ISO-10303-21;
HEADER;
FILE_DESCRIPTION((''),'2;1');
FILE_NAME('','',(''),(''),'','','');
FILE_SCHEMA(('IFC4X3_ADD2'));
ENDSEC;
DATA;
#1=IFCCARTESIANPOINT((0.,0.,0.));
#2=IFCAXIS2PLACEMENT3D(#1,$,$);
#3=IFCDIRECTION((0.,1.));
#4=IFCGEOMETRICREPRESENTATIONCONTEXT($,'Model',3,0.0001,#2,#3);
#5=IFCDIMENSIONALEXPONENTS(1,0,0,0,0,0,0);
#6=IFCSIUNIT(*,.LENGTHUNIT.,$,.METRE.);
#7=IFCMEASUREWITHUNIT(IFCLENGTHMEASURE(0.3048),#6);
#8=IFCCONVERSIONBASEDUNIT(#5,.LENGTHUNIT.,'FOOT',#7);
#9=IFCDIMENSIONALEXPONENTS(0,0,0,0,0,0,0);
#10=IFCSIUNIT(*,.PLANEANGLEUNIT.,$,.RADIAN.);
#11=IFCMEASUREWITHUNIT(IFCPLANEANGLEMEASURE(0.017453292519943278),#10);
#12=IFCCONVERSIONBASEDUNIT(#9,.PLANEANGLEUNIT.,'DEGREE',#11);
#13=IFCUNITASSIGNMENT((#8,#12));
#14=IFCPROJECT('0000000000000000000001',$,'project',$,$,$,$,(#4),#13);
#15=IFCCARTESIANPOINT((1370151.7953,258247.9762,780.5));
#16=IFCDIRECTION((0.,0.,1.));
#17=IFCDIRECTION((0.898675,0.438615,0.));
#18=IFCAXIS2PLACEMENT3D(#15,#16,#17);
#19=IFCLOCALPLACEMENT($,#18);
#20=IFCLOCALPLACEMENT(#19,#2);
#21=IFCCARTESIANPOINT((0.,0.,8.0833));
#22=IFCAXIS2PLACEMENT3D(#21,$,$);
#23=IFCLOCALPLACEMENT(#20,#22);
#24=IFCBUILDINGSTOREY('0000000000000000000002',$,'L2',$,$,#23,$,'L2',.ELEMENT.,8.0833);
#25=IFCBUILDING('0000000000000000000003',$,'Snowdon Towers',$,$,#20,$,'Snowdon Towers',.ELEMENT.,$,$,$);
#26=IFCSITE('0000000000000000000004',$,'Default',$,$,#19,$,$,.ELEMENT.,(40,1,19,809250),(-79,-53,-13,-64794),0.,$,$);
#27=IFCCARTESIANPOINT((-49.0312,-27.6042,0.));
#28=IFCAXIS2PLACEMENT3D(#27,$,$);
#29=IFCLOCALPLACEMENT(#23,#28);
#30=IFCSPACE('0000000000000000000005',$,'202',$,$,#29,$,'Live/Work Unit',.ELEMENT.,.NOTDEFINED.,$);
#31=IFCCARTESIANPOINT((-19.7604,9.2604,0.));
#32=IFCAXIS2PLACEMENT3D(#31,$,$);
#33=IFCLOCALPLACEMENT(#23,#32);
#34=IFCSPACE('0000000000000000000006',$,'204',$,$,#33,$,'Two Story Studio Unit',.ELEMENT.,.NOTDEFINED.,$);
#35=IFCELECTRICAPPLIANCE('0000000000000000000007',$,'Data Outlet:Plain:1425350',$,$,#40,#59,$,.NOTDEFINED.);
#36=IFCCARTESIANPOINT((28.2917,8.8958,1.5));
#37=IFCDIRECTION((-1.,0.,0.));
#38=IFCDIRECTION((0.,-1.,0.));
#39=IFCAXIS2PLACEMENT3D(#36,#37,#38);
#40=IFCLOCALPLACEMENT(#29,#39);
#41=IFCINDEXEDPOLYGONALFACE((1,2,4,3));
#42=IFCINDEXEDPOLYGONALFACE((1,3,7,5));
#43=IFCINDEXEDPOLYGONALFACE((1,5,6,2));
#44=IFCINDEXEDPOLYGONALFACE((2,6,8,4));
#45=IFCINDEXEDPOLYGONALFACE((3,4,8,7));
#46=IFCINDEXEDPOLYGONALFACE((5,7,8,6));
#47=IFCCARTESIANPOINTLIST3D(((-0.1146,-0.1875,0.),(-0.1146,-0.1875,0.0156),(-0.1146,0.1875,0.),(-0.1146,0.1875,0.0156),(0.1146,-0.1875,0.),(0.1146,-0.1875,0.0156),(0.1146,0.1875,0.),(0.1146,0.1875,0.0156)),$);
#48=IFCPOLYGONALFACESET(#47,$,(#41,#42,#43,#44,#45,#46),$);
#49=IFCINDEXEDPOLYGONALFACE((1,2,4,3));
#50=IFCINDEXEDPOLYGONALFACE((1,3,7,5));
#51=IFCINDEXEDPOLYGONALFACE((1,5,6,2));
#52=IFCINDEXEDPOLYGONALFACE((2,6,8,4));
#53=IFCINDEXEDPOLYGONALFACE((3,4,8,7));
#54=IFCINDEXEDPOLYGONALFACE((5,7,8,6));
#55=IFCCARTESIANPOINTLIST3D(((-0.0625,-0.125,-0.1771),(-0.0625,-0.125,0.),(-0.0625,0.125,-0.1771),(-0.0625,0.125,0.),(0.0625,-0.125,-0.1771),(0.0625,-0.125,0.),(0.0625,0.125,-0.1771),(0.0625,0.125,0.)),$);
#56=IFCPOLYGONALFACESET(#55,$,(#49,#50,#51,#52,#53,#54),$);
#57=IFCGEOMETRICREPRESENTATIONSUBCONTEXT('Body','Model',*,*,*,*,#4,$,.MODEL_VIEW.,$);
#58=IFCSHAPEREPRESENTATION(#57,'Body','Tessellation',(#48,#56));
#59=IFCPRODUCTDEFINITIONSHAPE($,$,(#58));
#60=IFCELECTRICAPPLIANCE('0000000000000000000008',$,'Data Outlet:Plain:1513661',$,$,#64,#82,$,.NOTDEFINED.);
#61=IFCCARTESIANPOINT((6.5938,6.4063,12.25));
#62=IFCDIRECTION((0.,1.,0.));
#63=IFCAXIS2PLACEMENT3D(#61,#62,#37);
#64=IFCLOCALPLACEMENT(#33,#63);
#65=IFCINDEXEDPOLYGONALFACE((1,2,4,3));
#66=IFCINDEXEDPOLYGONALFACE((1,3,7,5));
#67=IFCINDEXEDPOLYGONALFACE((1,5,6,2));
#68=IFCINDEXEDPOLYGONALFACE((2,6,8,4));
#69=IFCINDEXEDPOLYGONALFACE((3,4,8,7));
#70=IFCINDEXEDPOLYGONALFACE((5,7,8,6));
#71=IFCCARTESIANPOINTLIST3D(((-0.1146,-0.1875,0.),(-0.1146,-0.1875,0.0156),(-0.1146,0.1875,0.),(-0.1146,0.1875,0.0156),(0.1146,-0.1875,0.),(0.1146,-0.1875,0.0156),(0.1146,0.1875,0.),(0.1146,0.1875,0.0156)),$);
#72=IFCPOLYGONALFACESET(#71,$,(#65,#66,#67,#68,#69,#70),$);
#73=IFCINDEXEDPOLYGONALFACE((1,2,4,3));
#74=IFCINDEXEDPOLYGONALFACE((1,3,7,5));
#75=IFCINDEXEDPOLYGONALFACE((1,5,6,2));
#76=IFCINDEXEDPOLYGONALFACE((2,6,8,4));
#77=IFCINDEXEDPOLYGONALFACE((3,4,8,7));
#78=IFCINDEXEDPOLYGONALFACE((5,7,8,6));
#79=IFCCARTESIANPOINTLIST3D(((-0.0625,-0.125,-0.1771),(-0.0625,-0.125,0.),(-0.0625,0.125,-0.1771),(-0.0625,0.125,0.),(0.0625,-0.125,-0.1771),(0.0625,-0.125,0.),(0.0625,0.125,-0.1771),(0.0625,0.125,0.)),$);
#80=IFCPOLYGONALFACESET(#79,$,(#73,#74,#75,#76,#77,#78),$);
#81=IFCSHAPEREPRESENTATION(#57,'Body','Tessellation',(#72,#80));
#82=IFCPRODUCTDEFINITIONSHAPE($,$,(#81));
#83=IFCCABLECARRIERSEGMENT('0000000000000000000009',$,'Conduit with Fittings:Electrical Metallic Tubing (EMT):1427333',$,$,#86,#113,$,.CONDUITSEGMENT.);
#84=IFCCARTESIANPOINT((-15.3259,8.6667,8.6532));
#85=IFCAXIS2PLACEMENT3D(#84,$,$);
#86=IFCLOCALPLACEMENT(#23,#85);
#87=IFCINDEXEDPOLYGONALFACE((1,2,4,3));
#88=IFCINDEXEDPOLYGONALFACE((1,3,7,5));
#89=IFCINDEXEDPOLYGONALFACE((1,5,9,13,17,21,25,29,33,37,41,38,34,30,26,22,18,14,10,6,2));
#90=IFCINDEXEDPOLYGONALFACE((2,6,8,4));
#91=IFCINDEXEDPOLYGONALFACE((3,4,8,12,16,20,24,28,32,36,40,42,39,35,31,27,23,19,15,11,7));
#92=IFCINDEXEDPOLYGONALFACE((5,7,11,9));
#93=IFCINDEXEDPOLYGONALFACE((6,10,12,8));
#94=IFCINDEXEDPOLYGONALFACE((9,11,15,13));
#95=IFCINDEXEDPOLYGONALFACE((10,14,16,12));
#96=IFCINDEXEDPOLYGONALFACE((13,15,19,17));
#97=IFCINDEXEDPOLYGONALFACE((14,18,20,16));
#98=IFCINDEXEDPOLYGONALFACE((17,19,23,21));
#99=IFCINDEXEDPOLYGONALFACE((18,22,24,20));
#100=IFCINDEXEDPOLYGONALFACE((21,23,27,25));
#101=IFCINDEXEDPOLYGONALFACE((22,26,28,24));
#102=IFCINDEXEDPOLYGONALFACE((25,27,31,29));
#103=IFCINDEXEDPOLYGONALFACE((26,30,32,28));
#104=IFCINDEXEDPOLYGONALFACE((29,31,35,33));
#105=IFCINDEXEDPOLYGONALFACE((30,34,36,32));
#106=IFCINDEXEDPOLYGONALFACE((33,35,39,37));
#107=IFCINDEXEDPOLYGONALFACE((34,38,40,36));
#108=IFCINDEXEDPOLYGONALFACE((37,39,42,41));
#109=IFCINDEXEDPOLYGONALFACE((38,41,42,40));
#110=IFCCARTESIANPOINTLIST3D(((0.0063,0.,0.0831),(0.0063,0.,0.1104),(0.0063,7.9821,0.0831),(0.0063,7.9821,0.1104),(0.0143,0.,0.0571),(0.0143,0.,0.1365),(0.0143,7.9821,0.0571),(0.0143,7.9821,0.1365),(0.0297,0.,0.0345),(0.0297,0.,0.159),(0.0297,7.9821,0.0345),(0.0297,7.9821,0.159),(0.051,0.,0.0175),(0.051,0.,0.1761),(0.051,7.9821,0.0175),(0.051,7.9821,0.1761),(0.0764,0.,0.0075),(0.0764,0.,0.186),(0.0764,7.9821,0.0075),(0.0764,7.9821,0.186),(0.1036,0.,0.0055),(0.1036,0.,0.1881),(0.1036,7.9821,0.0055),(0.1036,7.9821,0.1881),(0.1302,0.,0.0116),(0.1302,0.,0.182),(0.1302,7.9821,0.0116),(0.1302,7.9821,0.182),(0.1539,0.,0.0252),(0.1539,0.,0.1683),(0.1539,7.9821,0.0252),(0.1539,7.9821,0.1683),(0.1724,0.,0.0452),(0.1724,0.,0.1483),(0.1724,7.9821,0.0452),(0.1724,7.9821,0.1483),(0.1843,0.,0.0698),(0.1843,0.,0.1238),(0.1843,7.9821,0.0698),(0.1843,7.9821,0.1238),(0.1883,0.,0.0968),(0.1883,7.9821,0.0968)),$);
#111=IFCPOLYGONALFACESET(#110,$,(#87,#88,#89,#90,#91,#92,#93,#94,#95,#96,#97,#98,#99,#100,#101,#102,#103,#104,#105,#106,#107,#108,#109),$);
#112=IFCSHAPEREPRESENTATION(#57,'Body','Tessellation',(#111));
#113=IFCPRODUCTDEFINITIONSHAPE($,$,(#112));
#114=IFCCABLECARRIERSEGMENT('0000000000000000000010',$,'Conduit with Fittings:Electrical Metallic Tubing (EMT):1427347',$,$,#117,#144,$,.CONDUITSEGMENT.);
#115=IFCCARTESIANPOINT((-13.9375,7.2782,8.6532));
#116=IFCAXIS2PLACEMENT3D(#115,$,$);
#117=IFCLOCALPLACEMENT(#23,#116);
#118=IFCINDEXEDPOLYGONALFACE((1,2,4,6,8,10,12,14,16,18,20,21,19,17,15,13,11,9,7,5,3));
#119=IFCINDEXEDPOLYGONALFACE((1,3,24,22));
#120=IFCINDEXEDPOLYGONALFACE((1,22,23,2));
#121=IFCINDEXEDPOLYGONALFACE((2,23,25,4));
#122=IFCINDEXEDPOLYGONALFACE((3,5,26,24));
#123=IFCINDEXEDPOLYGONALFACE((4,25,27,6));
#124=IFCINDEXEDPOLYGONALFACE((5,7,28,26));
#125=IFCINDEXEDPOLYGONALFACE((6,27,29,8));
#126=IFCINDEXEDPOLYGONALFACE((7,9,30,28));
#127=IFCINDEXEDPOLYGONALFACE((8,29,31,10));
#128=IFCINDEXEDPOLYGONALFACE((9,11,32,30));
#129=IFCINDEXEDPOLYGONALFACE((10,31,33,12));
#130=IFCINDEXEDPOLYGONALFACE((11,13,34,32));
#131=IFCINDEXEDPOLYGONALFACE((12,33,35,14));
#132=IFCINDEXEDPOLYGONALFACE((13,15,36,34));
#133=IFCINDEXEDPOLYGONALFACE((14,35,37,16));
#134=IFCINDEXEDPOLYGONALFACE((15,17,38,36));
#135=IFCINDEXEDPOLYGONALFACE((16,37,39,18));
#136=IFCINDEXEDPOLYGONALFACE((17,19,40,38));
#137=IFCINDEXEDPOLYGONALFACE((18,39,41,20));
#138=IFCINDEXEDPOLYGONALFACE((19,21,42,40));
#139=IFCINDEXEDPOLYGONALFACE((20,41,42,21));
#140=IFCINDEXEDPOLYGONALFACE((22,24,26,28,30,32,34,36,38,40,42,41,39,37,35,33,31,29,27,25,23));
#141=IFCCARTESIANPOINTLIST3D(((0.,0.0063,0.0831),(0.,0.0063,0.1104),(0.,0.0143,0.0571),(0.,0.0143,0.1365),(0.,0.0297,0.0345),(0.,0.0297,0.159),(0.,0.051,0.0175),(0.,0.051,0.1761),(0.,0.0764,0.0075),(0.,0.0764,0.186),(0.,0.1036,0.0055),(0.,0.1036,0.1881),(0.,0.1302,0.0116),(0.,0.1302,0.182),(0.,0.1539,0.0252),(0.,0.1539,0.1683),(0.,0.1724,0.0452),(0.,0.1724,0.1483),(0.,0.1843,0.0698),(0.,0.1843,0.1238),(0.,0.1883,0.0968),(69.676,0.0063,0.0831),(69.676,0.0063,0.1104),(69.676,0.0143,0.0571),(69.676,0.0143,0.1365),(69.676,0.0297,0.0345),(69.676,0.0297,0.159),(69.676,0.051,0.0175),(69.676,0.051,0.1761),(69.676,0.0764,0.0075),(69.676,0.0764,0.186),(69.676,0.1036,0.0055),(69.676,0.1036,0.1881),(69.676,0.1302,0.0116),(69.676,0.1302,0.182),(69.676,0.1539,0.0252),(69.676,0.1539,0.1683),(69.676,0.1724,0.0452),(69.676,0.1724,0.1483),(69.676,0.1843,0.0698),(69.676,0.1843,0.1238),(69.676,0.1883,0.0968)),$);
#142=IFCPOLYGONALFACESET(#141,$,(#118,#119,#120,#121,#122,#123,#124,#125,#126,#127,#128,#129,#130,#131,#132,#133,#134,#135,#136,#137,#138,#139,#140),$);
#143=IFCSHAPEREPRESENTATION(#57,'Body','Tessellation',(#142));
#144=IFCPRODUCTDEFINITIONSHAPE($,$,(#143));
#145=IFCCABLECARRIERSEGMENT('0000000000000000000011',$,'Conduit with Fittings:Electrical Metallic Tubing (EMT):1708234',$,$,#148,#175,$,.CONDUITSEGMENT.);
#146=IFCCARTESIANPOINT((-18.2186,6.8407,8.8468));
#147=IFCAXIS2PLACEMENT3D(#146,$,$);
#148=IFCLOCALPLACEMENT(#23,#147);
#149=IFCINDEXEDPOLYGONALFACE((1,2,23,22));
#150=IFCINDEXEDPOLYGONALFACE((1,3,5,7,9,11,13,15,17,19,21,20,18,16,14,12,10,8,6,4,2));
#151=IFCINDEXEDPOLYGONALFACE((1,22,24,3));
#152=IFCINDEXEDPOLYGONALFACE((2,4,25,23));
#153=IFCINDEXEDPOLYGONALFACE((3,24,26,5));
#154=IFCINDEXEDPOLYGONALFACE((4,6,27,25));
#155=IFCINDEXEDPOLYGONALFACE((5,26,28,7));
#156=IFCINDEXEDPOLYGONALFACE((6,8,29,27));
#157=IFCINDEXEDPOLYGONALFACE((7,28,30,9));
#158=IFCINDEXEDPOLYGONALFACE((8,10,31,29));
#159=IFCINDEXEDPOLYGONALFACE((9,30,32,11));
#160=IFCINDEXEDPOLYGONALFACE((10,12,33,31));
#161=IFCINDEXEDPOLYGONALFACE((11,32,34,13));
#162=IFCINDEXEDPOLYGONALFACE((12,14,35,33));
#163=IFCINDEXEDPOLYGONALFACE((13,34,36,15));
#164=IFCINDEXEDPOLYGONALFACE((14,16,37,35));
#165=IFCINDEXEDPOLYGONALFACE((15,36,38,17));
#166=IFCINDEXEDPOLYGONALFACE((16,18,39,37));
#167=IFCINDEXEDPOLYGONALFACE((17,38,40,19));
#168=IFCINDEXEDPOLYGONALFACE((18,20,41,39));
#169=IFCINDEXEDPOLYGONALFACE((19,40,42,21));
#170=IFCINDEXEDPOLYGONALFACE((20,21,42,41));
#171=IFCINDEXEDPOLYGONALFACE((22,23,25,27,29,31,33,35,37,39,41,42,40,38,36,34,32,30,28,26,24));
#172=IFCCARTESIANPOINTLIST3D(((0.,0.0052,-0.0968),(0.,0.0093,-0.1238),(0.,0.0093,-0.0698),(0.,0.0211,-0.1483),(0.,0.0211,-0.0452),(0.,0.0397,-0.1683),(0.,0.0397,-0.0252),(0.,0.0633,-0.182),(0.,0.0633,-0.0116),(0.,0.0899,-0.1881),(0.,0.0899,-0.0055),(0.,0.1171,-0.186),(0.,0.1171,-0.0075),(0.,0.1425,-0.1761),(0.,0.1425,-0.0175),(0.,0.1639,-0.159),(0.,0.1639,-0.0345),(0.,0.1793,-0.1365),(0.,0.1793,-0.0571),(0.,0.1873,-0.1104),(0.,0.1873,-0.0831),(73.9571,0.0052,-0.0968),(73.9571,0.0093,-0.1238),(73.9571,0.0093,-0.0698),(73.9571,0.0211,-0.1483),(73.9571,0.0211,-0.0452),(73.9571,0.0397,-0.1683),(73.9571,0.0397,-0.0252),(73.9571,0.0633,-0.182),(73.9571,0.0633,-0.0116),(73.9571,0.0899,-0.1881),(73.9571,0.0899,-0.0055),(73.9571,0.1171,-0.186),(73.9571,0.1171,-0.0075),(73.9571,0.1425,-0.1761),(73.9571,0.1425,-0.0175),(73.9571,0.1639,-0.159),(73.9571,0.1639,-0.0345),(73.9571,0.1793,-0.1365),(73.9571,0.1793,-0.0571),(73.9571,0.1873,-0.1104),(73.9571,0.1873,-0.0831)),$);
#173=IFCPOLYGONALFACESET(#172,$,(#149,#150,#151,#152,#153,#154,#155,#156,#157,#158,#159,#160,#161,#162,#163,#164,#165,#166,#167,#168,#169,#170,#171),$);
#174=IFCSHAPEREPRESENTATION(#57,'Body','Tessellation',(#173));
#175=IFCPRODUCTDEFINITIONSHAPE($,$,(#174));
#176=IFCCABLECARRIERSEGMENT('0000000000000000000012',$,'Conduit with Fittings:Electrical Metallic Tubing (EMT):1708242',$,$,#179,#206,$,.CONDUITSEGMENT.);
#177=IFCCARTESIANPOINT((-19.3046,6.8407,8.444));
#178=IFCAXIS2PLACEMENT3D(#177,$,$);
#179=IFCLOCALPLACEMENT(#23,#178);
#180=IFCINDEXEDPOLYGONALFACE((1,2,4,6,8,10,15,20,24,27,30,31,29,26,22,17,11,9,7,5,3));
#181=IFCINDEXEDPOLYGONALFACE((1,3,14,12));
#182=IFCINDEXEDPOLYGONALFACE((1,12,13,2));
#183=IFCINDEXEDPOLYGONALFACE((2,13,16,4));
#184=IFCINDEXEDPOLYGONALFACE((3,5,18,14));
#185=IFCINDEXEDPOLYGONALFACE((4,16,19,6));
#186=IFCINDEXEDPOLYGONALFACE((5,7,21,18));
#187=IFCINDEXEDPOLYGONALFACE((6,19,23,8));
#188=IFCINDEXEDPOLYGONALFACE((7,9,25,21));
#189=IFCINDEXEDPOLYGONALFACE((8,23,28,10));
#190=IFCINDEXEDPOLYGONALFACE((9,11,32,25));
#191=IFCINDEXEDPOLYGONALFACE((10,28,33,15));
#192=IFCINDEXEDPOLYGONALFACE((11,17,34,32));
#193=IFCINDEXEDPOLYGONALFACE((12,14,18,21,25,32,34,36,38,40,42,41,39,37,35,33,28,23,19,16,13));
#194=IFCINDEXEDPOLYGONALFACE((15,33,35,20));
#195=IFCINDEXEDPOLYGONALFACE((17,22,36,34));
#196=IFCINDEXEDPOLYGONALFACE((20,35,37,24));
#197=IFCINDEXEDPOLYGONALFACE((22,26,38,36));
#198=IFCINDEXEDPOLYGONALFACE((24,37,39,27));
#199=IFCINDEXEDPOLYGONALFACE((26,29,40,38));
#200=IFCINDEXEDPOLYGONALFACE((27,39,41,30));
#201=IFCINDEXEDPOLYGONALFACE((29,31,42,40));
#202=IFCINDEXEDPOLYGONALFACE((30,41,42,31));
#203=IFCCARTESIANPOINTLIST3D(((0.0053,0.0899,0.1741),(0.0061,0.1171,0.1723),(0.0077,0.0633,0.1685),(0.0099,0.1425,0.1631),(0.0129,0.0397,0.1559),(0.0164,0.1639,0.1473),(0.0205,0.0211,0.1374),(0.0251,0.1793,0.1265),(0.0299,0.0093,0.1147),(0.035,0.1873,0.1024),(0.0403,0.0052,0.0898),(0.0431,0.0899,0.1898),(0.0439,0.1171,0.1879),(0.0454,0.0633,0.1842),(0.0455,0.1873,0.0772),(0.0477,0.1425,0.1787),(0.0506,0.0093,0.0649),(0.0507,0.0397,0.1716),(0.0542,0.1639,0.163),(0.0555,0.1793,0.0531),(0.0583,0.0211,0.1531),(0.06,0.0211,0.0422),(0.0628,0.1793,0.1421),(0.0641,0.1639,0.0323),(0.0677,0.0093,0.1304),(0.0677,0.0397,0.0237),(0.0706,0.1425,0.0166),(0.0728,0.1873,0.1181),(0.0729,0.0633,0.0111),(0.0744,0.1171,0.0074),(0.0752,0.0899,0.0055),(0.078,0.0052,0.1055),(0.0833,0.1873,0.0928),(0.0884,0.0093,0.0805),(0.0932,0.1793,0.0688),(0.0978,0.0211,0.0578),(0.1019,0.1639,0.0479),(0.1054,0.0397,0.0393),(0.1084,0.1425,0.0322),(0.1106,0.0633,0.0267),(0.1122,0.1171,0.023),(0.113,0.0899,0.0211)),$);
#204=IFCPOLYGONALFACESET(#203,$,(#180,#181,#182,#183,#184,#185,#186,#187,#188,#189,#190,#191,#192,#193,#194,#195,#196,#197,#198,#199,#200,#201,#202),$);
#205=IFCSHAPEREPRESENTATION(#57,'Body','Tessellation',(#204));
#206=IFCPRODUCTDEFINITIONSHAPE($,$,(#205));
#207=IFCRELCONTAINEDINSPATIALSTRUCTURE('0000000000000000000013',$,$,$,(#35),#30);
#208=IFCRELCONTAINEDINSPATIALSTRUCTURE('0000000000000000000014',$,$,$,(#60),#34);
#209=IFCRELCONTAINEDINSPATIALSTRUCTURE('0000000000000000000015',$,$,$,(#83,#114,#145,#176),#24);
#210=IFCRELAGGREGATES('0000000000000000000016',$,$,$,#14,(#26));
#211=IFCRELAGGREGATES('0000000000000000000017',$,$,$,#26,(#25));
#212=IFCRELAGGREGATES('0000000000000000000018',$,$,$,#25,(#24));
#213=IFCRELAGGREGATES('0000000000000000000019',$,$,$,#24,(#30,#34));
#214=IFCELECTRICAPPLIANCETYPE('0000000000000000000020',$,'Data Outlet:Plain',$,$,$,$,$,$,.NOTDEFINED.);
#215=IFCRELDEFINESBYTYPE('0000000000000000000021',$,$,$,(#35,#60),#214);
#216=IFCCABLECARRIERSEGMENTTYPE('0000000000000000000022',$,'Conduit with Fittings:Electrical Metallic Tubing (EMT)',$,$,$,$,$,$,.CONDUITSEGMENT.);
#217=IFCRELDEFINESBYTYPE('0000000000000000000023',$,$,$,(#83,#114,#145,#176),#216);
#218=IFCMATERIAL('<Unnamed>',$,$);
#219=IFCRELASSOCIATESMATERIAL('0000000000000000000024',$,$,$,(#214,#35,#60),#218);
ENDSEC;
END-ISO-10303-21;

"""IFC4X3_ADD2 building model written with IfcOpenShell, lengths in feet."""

from ifc_helpers import new_model, entity, si_unit, converted_unit, direction, frame, frame_2d, origin, origin_2d_with_axis, place, context, subcontext, project, spatial, rectangle, circle, extrude, source, transform, mapped, material, type_object, type_shapes, element, save


model = new_model("IFC4X3_ADD2")

# Units and contexts
model_context = context("Model", 3, precision=0.0001, world=origin(), true_north=direction((0.0, 1.0)))
body_context = subcontext(model_context, "Body", "Model", "MODEL_VIEW")
ifc_project = project(units=[converted_unit("LENGTHUNIT", "FOOT", entity("IfcLengthMeasure", 0.3048), si_unit("LENGTHUNIT", "METRE"), dimensions=[1, 0, 0, 0, 0, 0, 0]), converted_unit("PLANEANGLEUNIT", "DEGREE", entity("IfcPlaneAngleMeasure", 0.017453292519943278), si_unit("PLANEANGLEUNIT", "RADIAN"), dimensions=[0, 0, 0, 0, 0, 0, 0])], contexts=[model_context])

# Site, building, storey, space
site_placement = place(None, frame((1370151.7953, 258247.9762, 780.5), z_axis=(0.0, 0.0, 1.0), x_axis=(0.898675, 0.438615, 0.0)))
site = spatial("IfcSite", under=ifc_project, at=site_placement, Name="Default", CompositionType="ELEMENT", RefLatitude=(40, 1, 19, 809250), RefLongitude=(-79, -53, -13, -64794), RefElevation=0.0)
building_placement = place(site_placement, origin())
building = spatial("IfcBuilding", under=site, at=building_placement, Name="Snowdon Towers", LongName="Snowdon Towers", CompositionType="ELEMENT")
storey_placement = place(building_placement, frame((0.0, 0.0, 8.0833)))
storey = spatial("IfcBuildingStorey", under=building, at=storey_placement, Name="L2", LongName="L2", CompositionType="ELEMENT", Elevation=8.0833)
space_1_placement = place(storey_placement, frame((-49.0312, -27.6042, 0.0)))
space_1 = spatial("IfcSpace", under=storey, at=space_1_placement, Name="202", LongName="Live/Work Unit", CompositionType="ELEMENT", PredefinedType="NOTDEFINED")

# Electric appliance
ifc_material_1 = material(Name="<Unnamed>")
electric_appliance_type = type_object("IfcElectricApplianceType", Name="Data Outlet:Plain", PredefinedType="NOTDEFINED", material=ifc_material_1)
shared_shape_1 = source(origin(), body_context, "Body", "SweptSolid", [
    extrude(rectangle(XDim=0.2292, YDim=0.375, at=frame_2d((0.0, 0.0), x_axis=(1.0, 0.0))), frame((0.0, 0.0, 0.0), z_axis=(0.0, 0.0, 1.0), x_axis=(-1.0, 0.0, 0.0)), (0.0, 0.0, 1.0), 0.0156),
    extrude(rectangle(XDim=0.125, YDim=0.25, at=frame_2d((0.0, 0.0), x_axis=(1.0, 0.0))), frame((0.0, 0.0, -0.1771), z_axis=(0.0, 0.0, 1.0), x_axis=(-1.0, 0.0, 0.0)), (0.0, 0.0, 1.0), 0.1771),
])
type_shapes(electric_appliance_type, [shared_shape_1])
electric_appliance_1_placement = place(space_1_placement, frame((28.2917, 8.8958, 1.5), z_axis=(-1.0, 0.0, 0.0), x_axis=(0.0, -1.0, 0.0)))
element("IfcElectricAppliance", 1, at=electric_appliance_1_placement, inside=space_1, type_object=electric_appliance_type, material=ifc_material_1, Name="Data Outlet:Plain:1425350", PredefinedType="NOTDEFINED", context=body_context, shape_type="MappedRepresentation", body=[
    mapped(shared_shape_1, transform((0.0, 0.0, 0.0), scale=1.0)),
])

# Shared definitions
space_2_placement = place(storey_placement, frame((-19.7604, 9.2604, 0.0)))
space_2 = spatial("IfcSpace", under=storey, at=space_2_placement, Name="204", LongName="Two Story Studio Unit", CompositionType="ELEMENT", PredefinedType="NOTDEFINED")

# Electric appliance
electric_appliance_2_placement = place(space_2_placement, frame((6.5938, 6.4063, 12.25), z_axis=(0.0, 1.0, 0.0), x_axis=(-1.0, 0.0, 0.0)))
element("IfcElectricAppliance", 2, at=electric_appliance_2_placement, inside=space_2, type_object=electric_appliance_type, material=ifc_material_1, Name="Data Outlet:Plain:1513661", PredefinedType="NOTDEFINED", context=body_context, shape_type="MappedRepresentation", body=[
    mapped(shared_shape_1, transform((0.0, 0.0, 0.0), scale=1.0)),
])

# Cable carrier segments
cable_carrier_segment_type = type_object("IfcCableCarrierSegmentType", Name="Conduit with Fittings:Electrical Metallic Tubing (EMT)", PredefinedType="CONDUITSEGMENT")
cable_carrier_segment_1_placement = place(storey_placement, frame((-15.3259, 8.6667, 8.6532)))
element("IfcCableCarrierSegment", 3, at=cable_carrier_segment_1_placement, inside=storey, type_object=cable_carrier_segment_type, Name="Conduit with Fittings:Electrical Metallic Tubing (EMT):1427333", PredefinedType="CONDUITSEGMENT", context=body_context, shape_type="SweptSolid", body=[
    extrude(circle(Radius=0.0915, at=origin_2d_with_axis()), frame((0.0968, 0.0, 0.0968), z_axis=(0.0, 1.0, 0.0), x_axis=(1.0, 0.0, 0.0)), (0.0, 0.0, 1.0), 7.9821),
])
cable_carrier_segment_2_placement = place(storey_placement, frame((-13.9375, 7.2782, 8.6532)))
element("IfcCableCarrierSegment", 4, at=cable_carrier_segment_2_placement, inside=storey, type_object=cable_carrier_segment_type, Name="Conduit with Fittings:Electrical Metallic Tubing (EMT):1427347", PredefinedType="CONDUITSEGMENT", context=body_context, shape_type="SweptSolid", body=[
    extrude(circle(Radius=0.0915, at=origin_2d_with_axis()), frame((0.0, 0.0968, 0.0968), z_axis=(1.0, 0.0, 0.0), x_axis=(0.0, 1.0, 0.0)), (0.0, 0.0, 1.0), 69.676),
])
cable_carrier_segment_3_placement = place(storey_placement, frame((-18.2186, 6.8407, 8.8468)))
element("IfcCableCarrierSegment", 5, at=cable_carrier_segment_3_placement, inside=storey, type_object=cable_carrier_segment_type, Name="Conduit with Fittings:Electrical Metallic Tubing (EMT):1708234", PredefinedType="CONDUITSEGMENT", context=body_context, shape_type="SweptSolid", body=[
    extrude(circle(Radius=0.0915, at=origin_2d_with_axis()), frame((0.0, 0.0968, -0.0968), z_axis=(1.0, 0.0, 0.0), x_axis=(0.0, -1.0, 0.0)), (0.0, 0.0, 1.0), 73.9571),
])
cable_carrier_segment_4_placement = place(storey_placement, frame((-19.3046, 6.8407, 8.444)))
element("IfcCableCarrierSegment", 6, at=cable_carrier_segment_4_placement, inside=storey, type_object=cable_carrier_segment_type, Name="Conduit with Fittings:Electrical Metallic Tubing (EMT):1708242", PredefinedType="CONDUITSEGMENT", context=body_context, shape_type="SweptSolid", body=[
    extrude(circle(Radius=0.0915, at=frame_2d((0.0, 0.0), x_axis=(1.0, 0.0))), frame((0.0403, 0.0968, 0.0898), z_axis=(0.92388, 0.0, 0.382683), x_axis=(0.0, -1.0, 0.0)), (0.0, 0.0, 1.0), 0.0409),
])

save(model, "model.ifc")
